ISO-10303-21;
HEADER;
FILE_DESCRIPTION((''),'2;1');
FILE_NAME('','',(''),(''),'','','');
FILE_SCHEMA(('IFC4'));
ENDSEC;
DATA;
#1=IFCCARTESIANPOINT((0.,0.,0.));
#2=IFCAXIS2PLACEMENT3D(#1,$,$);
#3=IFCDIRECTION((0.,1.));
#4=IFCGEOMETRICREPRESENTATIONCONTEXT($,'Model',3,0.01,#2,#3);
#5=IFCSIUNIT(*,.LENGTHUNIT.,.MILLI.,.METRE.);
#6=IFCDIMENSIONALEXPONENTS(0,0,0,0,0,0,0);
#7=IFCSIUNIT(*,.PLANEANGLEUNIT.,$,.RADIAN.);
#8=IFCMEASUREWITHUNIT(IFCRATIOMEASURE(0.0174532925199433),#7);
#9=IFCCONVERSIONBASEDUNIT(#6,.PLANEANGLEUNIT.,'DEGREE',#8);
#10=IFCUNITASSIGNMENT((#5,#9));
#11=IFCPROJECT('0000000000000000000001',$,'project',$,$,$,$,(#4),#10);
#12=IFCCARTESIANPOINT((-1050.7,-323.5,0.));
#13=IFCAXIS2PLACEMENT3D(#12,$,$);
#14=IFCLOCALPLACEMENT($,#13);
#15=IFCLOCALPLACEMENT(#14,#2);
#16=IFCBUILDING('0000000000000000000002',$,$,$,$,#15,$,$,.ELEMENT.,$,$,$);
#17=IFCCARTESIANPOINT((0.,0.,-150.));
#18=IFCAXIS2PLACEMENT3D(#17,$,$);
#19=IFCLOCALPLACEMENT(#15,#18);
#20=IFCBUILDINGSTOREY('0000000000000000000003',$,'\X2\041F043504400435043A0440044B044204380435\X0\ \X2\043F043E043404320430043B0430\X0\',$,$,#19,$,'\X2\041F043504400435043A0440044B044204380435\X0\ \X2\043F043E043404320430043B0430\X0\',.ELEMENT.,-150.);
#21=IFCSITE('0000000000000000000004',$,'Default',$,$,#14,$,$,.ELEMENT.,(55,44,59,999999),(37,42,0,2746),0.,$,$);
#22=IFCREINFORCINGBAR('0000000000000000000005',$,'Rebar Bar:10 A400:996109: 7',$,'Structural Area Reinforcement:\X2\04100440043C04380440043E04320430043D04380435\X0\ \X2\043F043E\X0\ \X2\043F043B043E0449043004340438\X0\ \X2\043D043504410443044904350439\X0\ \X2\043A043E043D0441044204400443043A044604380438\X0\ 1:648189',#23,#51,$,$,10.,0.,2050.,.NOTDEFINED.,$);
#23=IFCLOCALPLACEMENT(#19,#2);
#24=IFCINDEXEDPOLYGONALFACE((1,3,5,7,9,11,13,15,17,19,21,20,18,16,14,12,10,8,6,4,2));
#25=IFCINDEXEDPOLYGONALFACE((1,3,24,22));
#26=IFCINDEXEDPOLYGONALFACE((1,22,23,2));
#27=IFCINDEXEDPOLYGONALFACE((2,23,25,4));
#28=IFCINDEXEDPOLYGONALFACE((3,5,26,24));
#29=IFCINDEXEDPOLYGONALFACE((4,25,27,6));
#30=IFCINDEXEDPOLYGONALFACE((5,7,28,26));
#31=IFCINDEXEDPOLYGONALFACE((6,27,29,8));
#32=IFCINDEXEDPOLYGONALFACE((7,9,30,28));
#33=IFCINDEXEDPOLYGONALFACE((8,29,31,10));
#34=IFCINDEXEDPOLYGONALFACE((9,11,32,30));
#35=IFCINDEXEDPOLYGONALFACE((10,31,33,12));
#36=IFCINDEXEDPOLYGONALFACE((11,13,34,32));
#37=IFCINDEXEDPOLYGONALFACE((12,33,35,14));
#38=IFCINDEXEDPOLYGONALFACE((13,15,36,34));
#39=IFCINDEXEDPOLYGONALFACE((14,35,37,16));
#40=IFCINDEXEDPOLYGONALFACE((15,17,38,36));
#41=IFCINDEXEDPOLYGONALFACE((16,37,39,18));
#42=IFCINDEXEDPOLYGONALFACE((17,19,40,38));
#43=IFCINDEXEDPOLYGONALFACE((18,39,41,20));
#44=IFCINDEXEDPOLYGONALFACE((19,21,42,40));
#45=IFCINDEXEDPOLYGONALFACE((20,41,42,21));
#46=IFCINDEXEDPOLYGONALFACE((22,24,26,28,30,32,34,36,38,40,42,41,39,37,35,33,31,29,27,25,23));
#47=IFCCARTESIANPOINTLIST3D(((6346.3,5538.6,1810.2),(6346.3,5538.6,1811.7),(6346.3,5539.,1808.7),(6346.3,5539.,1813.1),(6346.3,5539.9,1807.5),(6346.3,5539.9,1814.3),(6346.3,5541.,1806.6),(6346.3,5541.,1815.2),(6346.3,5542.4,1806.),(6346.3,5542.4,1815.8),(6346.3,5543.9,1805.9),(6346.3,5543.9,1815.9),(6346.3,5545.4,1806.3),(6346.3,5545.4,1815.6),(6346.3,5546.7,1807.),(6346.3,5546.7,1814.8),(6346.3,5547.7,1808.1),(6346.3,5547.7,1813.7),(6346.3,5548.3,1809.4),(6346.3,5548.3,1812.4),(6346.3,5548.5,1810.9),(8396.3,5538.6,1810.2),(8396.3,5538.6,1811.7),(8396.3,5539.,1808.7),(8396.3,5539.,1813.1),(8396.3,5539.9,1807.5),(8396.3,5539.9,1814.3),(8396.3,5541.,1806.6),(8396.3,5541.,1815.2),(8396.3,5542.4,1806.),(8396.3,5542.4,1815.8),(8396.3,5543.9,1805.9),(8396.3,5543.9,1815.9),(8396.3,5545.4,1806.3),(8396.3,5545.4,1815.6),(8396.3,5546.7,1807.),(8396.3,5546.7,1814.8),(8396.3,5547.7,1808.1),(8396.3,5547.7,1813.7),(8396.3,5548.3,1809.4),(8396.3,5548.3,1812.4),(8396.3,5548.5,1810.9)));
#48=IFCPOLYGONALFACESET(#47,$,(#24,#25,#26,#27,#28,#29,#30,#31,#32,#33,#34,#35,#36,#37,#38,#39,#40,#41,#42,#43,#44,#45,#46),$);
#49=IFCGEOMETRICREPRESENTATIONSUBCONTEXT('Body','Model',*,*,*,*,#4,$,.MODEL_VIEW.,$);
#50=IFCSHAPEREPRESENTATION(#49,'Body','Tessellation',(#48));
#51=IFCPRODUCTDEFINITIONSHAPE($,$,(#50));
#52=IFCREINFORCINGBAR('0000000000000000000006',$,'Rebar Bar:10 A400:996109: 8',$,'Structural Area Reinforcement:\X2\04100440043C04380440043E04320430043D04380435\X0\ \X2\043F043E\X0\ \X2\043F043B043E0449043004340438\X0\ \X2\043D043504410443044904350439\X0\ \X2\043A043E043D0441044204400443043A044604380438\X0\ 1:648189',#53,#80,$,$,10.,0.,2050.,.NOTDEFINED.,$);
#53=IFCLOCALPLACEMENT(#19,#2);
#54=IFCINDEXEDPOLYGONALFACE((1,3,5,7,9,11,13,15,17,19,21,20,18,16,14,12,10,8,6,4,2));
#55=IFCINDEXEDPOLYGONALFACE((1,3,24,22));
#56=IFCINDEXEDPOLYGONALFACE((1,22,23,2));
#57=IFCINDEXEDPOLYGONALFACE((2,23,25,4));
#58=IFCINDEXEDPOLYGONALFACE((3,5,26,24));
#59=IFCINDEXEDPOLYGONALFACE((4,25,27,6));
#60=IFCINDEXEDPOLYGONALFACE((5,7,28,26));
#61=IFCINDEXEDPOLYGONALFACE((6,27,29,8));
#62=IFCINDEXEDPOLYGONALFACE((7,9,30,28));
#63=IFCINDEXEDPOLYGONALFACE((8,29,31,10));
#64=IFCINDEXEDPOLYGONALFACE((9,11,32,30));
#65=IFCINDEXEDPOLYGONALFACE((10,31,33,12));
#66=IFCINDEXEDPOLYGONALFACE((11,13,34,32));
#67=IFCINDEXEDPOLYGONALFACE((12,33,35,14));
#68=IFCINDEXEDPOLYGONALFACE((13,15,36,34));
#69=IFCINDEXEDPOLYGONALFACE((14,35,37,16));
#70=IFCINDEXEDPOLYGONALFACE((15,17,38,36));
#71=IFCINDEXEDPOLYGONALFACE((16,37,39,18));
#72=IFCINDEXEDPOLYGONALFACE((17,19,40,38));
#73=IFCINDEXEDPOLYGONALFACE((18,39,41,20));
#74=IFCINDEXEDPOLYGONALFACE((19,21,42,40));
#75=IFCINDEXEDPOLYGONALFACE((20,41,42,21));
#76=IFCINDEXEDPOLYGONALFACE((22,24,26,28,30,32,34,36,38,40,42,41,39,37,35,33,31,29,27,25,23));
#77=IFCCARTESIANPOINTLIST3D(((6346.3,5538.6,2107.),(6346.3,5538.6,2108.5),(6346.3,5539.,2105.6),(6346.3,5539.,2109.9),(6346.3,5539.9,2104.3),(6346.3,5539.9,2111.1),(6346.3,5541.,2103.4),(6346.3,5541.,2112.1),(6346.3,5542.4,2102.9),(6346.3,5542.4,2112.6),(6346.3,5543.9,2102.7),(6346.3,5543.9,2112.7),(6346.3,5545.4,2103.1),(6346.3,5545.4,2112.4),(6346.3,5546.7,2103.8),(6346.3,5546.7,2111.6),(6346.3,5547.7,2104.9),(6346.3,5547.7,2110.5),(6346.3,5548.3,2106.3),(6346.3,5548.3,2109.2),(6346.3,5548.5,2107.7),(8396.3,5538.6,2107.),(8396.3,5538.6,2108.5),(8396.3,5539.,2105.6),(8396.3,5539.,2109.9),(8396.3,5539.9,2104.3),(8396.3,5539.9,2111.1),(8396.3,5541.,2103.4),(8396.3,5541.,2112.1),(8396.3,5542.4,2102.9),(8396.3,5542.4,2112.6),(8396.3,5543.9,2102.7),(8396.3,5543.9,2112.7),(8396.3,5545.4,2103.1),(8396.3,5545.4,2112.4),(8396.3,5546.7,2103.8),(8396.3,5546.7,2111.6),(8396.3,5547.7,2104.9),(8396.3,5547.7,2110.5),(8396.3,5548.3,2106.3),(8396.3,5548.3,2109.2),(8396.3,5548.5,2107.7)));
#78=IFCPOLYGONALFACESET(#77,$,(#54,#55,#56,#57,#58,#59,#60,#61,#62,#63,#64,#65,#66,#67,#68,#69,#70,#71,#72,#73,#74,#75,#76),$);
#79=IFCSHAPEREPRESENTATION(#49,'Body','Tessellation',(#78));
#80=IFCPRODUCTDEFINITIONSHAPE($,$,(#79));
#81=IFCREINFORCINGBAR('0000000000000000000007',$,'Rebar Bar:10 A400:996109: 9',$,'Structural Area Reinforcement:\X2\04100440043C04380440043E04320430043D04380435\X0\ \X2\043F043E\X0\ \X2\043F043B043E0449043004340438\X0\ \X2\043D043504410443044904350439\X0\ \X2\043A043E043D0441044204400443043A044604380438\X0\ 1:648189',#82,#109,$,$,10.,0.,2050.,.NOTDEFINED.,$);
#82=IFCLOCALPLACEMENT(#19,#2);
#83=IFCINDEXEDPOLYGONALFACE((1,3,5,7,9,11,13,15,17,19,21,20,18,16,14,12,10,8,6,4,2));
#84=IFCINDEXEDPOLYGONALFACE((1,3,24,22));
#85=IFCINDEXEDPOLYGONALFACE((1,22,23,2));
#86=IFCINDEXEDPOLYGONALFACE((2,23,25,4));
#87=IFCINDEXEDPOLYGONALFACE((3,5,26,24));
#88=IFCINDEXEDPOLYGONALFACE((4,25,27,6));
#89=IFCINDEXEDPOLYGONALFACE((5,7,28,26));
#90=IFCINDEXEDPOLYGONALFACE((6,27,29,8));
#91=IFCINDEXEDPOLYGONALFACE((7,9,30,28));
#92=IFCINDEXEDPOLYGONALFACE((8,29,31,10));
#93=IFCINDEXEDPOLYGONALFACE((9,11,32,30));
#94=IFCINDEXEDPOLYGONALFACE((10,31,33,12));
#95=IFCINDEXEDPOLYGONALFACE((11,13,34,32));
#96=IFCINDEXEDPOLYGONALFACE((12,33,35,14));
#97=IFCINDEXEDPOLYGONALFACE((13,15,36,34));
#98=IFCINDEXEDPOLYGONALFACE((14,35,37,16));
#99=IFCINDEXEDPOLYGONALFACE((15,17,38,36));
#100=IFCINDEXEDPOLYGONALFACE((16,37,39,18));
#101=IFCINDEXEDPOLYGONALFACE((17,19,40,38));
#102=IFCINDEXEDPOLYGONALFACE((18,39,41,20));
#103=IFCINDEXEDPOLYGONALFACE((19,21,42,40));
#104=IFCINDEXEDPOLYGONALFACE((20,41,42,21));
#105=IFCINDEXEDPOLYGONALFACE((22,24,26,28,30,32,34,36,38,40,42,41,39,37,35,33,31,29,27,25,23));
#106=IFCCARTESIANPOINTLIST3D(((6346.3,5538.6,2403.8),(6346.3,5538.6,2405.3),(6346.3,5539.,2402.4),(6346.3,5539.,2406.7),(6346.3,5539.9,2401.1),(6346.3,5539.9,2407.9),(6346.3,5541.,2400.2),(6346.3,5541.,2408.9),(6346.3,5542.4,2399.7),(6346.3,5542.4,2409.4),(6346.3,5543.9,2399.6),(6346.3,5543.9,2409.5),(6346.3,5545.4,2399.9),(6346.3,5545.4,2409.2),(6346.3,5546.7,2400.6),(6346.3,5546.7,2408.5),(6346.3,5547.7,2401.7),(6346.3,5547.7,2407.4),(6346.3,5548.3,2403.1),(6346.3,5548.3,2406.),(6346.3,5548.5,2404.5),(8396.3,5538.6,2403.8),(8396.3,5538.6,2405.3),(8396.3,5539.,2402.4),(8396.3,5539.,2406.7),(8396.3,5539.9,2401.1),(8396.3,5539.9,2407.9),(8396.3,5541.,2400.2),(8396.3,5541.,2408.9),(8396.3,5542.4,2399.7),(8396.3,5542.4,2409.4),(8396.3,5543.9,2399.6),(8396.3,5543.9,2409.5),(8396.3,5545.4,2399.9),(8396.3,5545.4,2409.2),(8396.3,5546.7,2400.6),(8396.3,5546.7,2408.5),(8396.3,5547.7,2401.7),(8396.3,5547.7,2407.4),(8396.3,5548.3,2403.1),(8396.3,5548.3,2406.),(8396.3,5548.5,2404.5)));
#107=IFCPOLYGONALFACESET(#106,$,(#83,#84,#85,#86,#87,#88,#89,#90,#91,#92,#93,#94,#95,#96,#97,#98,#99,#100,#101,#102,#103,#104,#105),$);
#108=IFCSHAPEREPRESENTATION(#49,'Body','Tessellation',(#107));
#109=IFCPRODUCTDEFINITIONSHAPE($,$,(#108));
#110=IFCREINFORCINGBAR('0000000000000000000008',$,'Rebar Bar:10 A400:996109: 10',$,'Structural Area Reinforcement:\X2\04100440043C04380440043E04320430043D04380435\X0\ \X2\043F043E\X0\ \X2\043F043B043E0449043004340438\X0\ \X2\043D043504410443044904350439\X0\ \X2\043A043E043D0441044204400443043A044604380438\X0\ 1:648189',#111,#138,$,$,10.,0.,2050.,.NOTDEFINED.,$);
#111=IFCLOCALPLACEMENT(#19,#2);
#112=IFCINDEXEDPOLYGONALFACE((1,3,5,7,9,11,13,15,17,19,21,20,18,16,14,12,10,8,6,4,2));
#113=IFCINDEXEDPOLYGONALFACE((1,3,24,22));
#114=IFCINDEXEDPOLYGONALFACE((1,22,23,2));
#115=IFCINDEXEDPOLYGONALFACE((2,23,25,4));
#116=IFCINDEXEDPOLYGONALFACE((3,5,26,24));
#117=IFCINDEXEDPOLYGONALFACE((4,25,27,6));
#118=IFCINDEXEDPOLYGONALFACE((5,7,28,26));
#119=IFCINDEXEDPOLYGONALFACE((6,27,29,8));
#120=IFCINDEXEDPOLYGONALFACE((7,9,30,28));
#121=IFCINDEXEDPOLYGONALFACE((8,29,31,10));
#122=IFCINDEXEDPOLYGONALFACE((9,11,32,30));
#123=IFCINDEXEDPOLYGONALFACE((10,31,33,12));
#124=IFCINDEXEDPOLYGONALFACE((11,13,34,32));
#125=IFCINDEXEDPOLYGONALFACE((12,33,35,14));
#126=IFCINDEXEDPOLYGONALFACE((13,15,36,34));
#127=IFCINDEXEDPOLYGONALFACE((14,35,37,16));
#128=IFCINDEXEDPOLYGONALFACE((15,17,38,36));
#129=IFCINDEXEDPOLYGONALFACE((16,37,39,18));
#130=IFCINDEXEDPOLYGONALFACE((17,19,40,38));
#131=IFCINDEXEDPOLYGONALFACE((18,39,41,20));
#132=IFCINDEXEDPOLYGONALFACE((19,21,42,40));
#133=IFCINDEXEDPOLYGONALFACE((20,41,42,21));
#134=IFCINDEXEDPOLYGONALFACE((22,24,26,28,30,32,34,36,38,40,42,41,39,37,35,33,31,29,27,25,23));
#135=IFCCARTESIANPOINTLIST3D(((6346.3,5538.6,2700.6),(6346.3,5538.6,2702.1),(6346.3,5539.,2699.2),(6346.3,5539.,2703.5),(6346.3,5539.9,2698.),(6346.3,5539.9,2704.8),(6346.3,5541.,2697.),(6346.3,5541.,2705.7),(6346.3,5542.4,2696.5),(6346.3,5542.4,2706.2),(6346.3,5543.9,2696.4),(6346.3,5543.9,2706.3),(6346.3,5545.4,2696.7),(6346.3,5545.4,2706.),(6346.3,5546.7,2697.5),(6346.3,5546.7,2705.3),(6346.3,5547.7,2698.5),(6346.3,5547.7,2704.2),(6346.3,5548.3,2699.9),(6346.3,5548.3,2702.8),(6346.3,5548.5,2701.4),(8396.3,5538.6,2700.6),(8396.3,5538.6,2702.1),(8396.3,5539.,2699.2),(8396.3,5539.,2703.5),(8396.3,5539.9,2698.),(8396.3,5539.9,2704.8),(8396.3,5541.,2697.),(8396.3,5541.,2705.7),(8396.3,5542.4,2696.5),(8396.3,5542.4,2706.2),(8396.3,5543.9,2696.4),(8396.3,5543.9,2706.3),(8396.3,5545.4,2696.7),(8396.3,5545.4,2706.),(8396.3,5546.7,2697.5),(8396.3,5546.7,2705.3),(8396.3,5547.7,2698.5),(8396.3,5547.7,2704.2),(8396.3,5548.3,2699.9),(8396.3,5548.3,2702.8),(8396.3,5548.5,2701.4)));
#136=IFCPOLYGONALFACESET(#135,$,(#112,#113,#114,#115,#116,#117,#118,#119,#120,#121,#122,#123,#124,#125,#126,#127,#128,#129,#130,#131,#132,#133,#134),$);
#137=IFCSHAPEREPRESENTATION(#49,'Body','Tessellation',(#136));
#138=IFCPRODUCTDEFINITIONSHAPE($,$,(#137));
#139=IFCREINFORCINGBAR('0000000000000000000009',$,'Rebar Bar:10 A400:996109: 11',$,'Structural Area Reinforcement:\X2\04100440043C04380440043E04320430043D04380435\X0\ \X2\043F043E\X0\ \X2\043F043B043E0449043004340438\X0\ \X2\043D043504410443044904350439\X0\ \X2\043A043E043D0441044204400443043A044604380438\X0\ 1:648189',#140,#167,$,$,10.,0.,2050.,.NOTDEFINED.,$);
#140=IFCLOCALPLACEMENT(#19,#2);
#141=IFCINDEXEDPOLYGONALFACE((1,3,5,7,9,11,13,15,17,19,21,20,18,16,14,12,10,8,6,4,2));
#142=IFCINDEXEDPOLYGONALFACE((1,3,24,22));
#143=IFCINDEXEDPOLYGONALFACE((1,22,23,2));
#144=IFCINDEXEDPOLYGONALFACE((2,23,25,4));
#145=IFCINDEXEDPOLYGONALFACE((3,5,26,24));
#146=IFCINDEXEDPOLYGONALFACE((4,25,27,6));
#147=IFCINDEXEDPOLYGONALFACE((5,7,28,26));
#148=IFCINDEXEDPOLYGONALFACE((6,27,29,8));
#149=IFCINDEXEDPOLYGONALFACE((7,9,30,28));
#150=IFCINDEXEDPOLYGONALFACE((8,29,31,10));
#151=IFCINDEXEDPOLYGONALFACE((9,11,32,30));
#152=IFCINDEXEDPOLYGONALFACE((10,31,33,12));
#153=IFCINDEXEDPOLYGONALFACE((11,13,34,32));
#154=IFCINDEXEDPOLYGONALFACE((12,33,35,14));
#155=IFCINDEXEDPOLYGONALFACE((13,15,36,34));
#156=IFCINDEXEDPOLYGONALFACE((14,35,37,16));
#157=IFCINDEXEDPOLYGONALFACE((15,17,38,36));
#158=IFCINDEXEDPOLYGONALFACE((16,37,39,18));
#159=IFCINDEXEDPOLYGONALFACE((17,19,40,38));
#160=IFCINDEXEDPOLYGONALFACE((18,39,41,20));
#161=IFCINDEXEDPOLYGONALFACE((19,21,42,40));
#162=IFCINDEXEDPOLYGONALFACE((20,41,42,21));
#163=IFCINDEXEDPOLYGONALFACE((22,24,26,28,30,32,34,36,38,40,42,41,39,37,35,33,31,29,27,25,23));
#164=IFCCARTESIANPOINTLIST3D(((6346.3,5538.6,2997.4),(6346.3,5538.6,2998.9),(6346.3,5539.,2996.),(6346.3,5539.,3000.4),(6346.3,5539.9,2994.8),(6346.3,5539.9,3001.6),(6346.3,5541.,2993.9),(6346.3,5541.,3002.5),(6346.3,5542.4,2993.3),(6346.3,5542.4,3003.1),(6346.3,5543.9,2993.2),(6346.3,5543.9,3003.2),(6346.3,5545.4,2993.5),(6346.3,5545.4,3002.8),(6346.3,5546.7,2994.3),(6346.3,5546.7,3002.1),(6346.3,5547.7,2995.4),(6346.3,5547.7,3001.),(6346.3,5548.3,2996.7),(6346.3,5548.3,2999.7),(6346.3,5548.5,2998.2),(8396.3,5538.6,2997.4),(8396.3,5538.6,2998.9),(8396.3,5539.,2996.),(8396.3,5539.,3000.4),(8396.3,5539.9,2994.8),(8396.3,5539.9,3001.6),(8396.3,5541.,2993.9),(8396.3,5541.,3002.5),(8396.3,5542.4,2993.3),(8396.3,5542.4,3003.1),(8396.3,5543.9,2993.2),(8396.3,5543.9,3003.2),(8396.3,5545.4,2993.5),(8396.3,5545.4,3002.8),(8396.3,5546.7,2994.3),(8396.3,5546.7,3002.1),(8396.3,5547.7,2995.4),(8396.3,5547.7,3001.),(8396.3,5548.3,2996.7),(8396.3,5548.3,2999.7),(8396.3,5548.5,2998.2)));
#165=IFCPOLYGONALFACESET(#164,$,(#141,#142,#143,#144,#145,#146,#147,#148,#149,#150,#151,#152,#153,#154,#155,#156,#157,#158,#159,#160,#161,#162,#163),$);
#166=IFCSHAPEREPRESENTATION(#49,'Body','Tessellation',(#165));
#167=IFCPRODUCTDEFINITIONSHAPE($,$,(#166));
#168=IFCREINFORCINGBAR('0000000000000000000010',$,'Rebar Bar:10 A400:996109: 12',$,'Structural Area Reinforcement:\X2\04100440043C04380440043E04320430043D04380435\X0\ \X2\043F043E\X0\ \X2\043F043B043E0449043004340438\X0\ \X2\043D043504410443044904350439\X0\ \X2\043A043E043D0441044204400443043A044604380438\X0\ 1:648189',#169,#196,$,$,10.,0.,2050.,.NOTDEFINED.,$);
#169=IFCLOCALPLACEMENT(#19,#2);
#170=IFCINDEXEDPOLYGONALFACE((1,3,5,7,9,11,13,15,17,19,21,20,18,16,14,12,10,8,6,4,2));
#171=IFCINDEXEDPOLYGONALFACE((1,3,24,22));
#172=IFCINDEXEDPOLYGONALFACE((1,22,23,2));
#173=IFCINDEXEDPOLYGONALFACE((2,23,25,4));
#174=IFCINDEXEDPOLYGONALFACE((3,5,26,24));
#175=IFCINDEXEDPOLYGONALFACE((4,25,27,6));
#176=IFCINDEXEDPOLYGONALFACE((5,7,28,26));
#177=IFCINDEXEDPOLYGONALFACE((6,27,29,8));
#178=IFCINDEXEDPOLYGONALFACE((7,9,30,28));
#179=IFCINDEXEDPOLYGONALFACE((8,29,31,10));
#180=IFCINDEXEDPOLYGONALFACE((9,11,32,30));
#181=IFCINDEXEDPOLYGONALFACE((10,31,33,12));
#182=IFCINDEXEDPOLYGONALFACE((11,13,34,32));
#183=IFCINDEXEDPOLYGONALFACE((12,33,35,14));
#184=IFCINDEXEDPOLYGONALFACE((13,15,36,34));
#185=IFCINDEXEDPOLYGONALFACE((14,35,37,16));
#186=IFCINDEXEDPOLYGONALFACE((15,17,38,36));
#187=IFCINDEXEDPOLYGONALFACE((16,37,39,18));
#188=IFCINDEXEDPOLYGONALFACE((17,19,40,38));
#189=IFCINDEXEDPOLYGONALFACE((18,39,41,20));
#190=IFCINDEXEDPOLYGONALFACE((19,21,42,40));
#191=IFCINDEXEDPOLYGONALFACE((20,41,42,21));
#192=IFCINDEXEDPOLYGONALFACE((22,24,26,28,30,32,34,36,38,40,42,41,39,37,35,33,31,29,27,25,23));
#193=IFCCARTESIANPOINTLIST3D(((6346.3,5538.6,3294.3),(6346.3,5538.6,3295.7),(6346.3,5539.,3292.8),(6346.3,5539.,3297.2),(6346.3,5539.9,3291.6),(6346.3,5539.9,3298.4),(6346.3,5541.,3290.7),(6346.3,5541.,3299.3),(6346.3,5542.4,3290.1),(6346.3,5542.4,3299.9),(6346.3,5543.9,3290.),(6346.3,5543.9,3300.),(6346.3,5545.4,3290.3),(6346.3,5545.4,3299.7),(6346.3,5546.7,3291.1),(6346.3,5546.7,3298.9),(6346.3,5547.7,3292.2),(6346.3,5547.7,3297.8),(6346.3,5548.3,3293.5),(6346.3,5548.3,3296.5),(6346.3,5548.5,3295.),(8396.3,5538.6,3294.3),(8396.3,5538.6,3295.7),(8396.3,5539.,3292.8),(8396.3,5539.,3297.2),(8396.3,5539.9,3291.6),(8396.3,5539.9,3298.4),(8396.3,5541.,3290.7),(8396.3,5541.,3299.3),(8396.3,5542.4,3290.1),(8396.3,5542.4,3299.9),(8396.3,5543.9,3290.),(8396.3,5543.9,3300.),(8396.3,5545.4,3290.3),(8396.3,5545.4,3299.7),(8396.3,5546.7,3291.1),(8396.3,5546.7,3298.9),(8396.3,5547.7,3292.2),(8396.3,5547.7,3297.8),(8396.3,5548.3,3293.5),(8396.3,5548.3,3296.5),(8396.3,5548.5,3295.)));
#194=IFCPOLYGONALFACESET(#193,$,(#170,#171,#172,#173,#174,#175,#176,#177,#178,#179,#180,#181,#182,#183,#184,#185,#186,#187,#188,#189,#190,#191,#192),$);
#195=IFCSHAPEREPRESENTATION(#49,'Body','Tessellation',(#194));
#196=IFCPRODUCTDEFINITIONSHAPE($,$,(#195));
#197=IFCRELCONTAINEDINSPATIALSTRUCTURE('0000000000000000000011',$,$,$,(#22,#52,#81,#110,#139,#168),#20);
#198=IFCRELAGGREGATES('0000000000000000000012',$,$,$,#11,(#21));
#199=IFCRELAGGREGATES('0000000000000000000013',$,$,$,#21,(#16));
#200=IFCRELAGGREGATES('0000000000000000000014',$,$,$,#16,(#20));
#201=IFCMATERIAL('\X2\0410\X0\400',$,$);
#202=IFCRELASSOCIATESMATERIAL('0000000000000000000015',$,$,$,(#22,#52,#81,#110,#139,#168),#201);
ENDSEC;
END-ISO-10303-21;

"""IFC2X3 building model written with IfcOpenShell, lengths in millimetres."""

from ifc_helpers import new_model, entity, si_unit, converted_unit, direction, frame, origin, place, context, subcontext, project, spatial, material, element, save


model = new_model("IFC2X3")

# Units and contexts
model_context = context("Model", 3, precision=0.01, world=origin(), true_north=direction((0.0, 1.0)))
body_context = subcontext(model_context, "Body", "Model", "MODEL_VIEW")
ifc_project = project(units=[si_unit("LENGTHUNIT", "METRE", prefix="MILLI"), converted_unit("PLANEANGLEUNIT", "DEGREE", entity("IfcRatioMeasure", 0.0174532925199433), si_unit("PLANEANGLEUNIT", "RADIAN"), dimensions=[0, 0, 0, 0, 0, 0, 0])], contexts=[model_context])

# Site, building, storey
site_placement = place(None, frame((-1050.7, -323.5, 0.0)))
site = spatial("IfcSite", under=ifc_project, at=site_placement, Name="Default", CompositionType="ELEMENT", RefLatitude=(55, 44, 59, 999999), RefLongitude=(37, 42, 0, 2746), RefElevation=0.0)
building_placement = place(site_placement, origin())
building = spatial("IfcBuilding", under=site, at=building_placement, CompositionType="ELEMENT")
storey_placement = place(building_placement, frame((0.0, 0.0, -150.0)))
storey = spatial("IfcBuildingStorey", under=building, at=storey_placement, Name="Перекрытие подвала", LongName="Перекрытие подвала", CompositionType="ELEMENT", Elevation=-150.0)

# Reinforcing bars
ifc_material = material(Name="А400")
reinforcing_bar_1_placement = place(storey_placement, origin())
element("IfcReinforcingBar", 1, at=reinforcing_bar_1_placement, inside=storey, material=ifc_material, Name="Rebar Bar:10 A400:996109: 7", ObjectType="Structural Area Reinforcement:Армирование по площади несущей конструкции 1:648189", BarLength=2050.0, BarRole="NOTDEFINED", CrossSectionArea=0.0, NominalDiameter=10.0, context=body_context, shape_type="AdvancedSweptSolid", body=[
    entity("IfcSweptDiskSolid", entity("IfcCompositeCurve", [entity("IfcCompositeCurveSegment", "CONTINUOUS", True, entity("IfcPolyline", [entity("IfcCartesianPoint", [6346.3, 5543.5, 1810.9]), entity("IfcCartesianPoint", [8396.3, 5543.5, 1810.9])]))], False), 5.0, None, 0.0, 1.0),
])
reinforcing_bar_2_placement = place(storey_placement, origin())
element("IfcReinforcingBar", 2, at=reinforcing_bar_2_placement, inside=storey, material=ifc_material, Name="Rebar Bar:10 A400:996109: 8", ObjectType="Structural Area Reinforcement:Армирование по площади несущей конструкции 1:648189", BarLength=2050.0, BarRole="NOTDEFINED", CrossSectionArea=0.0, NominalDiameter=10.0, context=body_context, shape_type="AdvancedSweptSolid", body=[
    entity("IfcSweptDiskSolid", entity("IfcCompositeCurve", [entity("IfcCompositeCurveSegment", "CONTINUOUS", True, entity("IfcPolyline", [entity("IfcCartesianPoint", [6346.3, 5543.5, 2107.7]), entity("IfcCartesianPoint", [8396.3, 5543.5, 2107.7])]))], False), 5.0, None, 0.0, 1.0),
])
reinforcing_bar_3_placement = place(storey_placement, origin())
element("IfcReinforcingBar", 3, at=reinforcing_bar_3_placement, inside=storey, material=ifc_material, Name="Rebar Bar:10 A400:996109: 9", ObjectType="Structural Area Reinforcement:Армирование по площади несущей конструкции 1:648189", BarLength=2050.0, BarRole="NOTDEFINED", CrossSectionArea=0.0, NominalDiameter=10.0, context=body_context, shape_type="AdvancedSweptSolid", body=[
    entity("IfcSweptDiskSolid", entity("IfcCompositeCurve", [entity("IfcCompositeCurveSegment", "CONTINUOUS", True, entity("IfcPolyline", [entity("IfcCartesianPoint", [6346.3, 5543.5, 2404.5]), entity("IfcCartesianPoint", [8396.3, 5543.5, 2404.5])]))], False), 5.0, None, 0.0, 1.0),
])
reinforcing_bar_4_placement = place(storey_placement, origin())
element("IfcReinforcingBar", 4, at=reinforcing_bar_4_placement, inside=storey, material=ifc_material, Name="Rebar Bar:10 A400:996109: 10", ObjectType="Structural Area Reinforcement:Армирование по площади несущей конструкции 1:648189", BarLength=2050.0, BarRole="NOTDEFINED", CrossSectionArea=0.0, NominalDiameter=10.0, context=body_context, shape_type="AdvancedSweptSolid", body=[
    entity("IfcSweptDiskSolid", entity("IfcCompositeCurve", [entity("IfcCompositeCurveSegment", "CONTINUOUS", True, entity("IfcPolyline", [entity("IfcCartesianPoint", [6346.3, 5543.5, 2701.4]), entity("IfcCartesianPoint", [8396.3, 5543.5, 2701.4])]))], False), 5.0, None, 0.0, 1.0),
])
reinforcing_bar_5_placement = place(storey_placement, origin())
element("IfcReinforcingBar", 5, at=reinforcing_bar_5_placement, inside=storey, material=ifc_material, Name="Rebar Bar:10 A400:996109: 11", ObjectType="Structural Area Reinforcement:Армирование по площади несущей конструкции 1:648189", BarLength=2050.0, BarRole="NOTDEFINED", CrossSectionArea=0.0, NominalDiameter=10.0, context=body_context, shape_type="AdvancedSweptSolid", body=[
    entity("IfcSweptDiskSolid", entity("IfcCompositeCurve", [entity("IfcCompositeCurveSegment", "CONTINUOUS", True, entity("IfcPolyline", [entity("IfcCartesianPoint", [6346.3, 5543.5, 2998.2]), entity("IfcCartesianPoint", [8396.3, 5543.5, 2998.2])]))], False), 5.0, None, 0.0, 1.0),
])
reinforcing_bar_6_placement = place(storey_placement, origin())
element("IfcReinforcingBar", 6, at=reinforcing_bar_6_placement, inside=storey, material=ifc_material, Name="Rebar Bar:10 A400:996109: 12", ObjectType="Structural Area Reinforcement:Армирование по площади несущей конструкции 1:648189", BarLength=2050.0, BarRole="NOTDEFINED", CrossSectionArea=0.0, NominalDiameter=10.0, context=body_context, shape_type="AdvancedSweptSolid", body=[
    entity("IfcSweptDiskSolid", entity("IfcCompositeCurve", [entity("IfcCompositeCurveSegment", "CONTINUOUS", True, entity("IfcPolyline", [entity("IfcCartesianPoint", [6346.3, 5543.5, 3295.0]), entity("IfcCartesianPoint", [8396.3, 5543.5, 3295.0])]))], False), 5.0, None, 0.0, 1.0),
])

save(model, "model.ifc")
